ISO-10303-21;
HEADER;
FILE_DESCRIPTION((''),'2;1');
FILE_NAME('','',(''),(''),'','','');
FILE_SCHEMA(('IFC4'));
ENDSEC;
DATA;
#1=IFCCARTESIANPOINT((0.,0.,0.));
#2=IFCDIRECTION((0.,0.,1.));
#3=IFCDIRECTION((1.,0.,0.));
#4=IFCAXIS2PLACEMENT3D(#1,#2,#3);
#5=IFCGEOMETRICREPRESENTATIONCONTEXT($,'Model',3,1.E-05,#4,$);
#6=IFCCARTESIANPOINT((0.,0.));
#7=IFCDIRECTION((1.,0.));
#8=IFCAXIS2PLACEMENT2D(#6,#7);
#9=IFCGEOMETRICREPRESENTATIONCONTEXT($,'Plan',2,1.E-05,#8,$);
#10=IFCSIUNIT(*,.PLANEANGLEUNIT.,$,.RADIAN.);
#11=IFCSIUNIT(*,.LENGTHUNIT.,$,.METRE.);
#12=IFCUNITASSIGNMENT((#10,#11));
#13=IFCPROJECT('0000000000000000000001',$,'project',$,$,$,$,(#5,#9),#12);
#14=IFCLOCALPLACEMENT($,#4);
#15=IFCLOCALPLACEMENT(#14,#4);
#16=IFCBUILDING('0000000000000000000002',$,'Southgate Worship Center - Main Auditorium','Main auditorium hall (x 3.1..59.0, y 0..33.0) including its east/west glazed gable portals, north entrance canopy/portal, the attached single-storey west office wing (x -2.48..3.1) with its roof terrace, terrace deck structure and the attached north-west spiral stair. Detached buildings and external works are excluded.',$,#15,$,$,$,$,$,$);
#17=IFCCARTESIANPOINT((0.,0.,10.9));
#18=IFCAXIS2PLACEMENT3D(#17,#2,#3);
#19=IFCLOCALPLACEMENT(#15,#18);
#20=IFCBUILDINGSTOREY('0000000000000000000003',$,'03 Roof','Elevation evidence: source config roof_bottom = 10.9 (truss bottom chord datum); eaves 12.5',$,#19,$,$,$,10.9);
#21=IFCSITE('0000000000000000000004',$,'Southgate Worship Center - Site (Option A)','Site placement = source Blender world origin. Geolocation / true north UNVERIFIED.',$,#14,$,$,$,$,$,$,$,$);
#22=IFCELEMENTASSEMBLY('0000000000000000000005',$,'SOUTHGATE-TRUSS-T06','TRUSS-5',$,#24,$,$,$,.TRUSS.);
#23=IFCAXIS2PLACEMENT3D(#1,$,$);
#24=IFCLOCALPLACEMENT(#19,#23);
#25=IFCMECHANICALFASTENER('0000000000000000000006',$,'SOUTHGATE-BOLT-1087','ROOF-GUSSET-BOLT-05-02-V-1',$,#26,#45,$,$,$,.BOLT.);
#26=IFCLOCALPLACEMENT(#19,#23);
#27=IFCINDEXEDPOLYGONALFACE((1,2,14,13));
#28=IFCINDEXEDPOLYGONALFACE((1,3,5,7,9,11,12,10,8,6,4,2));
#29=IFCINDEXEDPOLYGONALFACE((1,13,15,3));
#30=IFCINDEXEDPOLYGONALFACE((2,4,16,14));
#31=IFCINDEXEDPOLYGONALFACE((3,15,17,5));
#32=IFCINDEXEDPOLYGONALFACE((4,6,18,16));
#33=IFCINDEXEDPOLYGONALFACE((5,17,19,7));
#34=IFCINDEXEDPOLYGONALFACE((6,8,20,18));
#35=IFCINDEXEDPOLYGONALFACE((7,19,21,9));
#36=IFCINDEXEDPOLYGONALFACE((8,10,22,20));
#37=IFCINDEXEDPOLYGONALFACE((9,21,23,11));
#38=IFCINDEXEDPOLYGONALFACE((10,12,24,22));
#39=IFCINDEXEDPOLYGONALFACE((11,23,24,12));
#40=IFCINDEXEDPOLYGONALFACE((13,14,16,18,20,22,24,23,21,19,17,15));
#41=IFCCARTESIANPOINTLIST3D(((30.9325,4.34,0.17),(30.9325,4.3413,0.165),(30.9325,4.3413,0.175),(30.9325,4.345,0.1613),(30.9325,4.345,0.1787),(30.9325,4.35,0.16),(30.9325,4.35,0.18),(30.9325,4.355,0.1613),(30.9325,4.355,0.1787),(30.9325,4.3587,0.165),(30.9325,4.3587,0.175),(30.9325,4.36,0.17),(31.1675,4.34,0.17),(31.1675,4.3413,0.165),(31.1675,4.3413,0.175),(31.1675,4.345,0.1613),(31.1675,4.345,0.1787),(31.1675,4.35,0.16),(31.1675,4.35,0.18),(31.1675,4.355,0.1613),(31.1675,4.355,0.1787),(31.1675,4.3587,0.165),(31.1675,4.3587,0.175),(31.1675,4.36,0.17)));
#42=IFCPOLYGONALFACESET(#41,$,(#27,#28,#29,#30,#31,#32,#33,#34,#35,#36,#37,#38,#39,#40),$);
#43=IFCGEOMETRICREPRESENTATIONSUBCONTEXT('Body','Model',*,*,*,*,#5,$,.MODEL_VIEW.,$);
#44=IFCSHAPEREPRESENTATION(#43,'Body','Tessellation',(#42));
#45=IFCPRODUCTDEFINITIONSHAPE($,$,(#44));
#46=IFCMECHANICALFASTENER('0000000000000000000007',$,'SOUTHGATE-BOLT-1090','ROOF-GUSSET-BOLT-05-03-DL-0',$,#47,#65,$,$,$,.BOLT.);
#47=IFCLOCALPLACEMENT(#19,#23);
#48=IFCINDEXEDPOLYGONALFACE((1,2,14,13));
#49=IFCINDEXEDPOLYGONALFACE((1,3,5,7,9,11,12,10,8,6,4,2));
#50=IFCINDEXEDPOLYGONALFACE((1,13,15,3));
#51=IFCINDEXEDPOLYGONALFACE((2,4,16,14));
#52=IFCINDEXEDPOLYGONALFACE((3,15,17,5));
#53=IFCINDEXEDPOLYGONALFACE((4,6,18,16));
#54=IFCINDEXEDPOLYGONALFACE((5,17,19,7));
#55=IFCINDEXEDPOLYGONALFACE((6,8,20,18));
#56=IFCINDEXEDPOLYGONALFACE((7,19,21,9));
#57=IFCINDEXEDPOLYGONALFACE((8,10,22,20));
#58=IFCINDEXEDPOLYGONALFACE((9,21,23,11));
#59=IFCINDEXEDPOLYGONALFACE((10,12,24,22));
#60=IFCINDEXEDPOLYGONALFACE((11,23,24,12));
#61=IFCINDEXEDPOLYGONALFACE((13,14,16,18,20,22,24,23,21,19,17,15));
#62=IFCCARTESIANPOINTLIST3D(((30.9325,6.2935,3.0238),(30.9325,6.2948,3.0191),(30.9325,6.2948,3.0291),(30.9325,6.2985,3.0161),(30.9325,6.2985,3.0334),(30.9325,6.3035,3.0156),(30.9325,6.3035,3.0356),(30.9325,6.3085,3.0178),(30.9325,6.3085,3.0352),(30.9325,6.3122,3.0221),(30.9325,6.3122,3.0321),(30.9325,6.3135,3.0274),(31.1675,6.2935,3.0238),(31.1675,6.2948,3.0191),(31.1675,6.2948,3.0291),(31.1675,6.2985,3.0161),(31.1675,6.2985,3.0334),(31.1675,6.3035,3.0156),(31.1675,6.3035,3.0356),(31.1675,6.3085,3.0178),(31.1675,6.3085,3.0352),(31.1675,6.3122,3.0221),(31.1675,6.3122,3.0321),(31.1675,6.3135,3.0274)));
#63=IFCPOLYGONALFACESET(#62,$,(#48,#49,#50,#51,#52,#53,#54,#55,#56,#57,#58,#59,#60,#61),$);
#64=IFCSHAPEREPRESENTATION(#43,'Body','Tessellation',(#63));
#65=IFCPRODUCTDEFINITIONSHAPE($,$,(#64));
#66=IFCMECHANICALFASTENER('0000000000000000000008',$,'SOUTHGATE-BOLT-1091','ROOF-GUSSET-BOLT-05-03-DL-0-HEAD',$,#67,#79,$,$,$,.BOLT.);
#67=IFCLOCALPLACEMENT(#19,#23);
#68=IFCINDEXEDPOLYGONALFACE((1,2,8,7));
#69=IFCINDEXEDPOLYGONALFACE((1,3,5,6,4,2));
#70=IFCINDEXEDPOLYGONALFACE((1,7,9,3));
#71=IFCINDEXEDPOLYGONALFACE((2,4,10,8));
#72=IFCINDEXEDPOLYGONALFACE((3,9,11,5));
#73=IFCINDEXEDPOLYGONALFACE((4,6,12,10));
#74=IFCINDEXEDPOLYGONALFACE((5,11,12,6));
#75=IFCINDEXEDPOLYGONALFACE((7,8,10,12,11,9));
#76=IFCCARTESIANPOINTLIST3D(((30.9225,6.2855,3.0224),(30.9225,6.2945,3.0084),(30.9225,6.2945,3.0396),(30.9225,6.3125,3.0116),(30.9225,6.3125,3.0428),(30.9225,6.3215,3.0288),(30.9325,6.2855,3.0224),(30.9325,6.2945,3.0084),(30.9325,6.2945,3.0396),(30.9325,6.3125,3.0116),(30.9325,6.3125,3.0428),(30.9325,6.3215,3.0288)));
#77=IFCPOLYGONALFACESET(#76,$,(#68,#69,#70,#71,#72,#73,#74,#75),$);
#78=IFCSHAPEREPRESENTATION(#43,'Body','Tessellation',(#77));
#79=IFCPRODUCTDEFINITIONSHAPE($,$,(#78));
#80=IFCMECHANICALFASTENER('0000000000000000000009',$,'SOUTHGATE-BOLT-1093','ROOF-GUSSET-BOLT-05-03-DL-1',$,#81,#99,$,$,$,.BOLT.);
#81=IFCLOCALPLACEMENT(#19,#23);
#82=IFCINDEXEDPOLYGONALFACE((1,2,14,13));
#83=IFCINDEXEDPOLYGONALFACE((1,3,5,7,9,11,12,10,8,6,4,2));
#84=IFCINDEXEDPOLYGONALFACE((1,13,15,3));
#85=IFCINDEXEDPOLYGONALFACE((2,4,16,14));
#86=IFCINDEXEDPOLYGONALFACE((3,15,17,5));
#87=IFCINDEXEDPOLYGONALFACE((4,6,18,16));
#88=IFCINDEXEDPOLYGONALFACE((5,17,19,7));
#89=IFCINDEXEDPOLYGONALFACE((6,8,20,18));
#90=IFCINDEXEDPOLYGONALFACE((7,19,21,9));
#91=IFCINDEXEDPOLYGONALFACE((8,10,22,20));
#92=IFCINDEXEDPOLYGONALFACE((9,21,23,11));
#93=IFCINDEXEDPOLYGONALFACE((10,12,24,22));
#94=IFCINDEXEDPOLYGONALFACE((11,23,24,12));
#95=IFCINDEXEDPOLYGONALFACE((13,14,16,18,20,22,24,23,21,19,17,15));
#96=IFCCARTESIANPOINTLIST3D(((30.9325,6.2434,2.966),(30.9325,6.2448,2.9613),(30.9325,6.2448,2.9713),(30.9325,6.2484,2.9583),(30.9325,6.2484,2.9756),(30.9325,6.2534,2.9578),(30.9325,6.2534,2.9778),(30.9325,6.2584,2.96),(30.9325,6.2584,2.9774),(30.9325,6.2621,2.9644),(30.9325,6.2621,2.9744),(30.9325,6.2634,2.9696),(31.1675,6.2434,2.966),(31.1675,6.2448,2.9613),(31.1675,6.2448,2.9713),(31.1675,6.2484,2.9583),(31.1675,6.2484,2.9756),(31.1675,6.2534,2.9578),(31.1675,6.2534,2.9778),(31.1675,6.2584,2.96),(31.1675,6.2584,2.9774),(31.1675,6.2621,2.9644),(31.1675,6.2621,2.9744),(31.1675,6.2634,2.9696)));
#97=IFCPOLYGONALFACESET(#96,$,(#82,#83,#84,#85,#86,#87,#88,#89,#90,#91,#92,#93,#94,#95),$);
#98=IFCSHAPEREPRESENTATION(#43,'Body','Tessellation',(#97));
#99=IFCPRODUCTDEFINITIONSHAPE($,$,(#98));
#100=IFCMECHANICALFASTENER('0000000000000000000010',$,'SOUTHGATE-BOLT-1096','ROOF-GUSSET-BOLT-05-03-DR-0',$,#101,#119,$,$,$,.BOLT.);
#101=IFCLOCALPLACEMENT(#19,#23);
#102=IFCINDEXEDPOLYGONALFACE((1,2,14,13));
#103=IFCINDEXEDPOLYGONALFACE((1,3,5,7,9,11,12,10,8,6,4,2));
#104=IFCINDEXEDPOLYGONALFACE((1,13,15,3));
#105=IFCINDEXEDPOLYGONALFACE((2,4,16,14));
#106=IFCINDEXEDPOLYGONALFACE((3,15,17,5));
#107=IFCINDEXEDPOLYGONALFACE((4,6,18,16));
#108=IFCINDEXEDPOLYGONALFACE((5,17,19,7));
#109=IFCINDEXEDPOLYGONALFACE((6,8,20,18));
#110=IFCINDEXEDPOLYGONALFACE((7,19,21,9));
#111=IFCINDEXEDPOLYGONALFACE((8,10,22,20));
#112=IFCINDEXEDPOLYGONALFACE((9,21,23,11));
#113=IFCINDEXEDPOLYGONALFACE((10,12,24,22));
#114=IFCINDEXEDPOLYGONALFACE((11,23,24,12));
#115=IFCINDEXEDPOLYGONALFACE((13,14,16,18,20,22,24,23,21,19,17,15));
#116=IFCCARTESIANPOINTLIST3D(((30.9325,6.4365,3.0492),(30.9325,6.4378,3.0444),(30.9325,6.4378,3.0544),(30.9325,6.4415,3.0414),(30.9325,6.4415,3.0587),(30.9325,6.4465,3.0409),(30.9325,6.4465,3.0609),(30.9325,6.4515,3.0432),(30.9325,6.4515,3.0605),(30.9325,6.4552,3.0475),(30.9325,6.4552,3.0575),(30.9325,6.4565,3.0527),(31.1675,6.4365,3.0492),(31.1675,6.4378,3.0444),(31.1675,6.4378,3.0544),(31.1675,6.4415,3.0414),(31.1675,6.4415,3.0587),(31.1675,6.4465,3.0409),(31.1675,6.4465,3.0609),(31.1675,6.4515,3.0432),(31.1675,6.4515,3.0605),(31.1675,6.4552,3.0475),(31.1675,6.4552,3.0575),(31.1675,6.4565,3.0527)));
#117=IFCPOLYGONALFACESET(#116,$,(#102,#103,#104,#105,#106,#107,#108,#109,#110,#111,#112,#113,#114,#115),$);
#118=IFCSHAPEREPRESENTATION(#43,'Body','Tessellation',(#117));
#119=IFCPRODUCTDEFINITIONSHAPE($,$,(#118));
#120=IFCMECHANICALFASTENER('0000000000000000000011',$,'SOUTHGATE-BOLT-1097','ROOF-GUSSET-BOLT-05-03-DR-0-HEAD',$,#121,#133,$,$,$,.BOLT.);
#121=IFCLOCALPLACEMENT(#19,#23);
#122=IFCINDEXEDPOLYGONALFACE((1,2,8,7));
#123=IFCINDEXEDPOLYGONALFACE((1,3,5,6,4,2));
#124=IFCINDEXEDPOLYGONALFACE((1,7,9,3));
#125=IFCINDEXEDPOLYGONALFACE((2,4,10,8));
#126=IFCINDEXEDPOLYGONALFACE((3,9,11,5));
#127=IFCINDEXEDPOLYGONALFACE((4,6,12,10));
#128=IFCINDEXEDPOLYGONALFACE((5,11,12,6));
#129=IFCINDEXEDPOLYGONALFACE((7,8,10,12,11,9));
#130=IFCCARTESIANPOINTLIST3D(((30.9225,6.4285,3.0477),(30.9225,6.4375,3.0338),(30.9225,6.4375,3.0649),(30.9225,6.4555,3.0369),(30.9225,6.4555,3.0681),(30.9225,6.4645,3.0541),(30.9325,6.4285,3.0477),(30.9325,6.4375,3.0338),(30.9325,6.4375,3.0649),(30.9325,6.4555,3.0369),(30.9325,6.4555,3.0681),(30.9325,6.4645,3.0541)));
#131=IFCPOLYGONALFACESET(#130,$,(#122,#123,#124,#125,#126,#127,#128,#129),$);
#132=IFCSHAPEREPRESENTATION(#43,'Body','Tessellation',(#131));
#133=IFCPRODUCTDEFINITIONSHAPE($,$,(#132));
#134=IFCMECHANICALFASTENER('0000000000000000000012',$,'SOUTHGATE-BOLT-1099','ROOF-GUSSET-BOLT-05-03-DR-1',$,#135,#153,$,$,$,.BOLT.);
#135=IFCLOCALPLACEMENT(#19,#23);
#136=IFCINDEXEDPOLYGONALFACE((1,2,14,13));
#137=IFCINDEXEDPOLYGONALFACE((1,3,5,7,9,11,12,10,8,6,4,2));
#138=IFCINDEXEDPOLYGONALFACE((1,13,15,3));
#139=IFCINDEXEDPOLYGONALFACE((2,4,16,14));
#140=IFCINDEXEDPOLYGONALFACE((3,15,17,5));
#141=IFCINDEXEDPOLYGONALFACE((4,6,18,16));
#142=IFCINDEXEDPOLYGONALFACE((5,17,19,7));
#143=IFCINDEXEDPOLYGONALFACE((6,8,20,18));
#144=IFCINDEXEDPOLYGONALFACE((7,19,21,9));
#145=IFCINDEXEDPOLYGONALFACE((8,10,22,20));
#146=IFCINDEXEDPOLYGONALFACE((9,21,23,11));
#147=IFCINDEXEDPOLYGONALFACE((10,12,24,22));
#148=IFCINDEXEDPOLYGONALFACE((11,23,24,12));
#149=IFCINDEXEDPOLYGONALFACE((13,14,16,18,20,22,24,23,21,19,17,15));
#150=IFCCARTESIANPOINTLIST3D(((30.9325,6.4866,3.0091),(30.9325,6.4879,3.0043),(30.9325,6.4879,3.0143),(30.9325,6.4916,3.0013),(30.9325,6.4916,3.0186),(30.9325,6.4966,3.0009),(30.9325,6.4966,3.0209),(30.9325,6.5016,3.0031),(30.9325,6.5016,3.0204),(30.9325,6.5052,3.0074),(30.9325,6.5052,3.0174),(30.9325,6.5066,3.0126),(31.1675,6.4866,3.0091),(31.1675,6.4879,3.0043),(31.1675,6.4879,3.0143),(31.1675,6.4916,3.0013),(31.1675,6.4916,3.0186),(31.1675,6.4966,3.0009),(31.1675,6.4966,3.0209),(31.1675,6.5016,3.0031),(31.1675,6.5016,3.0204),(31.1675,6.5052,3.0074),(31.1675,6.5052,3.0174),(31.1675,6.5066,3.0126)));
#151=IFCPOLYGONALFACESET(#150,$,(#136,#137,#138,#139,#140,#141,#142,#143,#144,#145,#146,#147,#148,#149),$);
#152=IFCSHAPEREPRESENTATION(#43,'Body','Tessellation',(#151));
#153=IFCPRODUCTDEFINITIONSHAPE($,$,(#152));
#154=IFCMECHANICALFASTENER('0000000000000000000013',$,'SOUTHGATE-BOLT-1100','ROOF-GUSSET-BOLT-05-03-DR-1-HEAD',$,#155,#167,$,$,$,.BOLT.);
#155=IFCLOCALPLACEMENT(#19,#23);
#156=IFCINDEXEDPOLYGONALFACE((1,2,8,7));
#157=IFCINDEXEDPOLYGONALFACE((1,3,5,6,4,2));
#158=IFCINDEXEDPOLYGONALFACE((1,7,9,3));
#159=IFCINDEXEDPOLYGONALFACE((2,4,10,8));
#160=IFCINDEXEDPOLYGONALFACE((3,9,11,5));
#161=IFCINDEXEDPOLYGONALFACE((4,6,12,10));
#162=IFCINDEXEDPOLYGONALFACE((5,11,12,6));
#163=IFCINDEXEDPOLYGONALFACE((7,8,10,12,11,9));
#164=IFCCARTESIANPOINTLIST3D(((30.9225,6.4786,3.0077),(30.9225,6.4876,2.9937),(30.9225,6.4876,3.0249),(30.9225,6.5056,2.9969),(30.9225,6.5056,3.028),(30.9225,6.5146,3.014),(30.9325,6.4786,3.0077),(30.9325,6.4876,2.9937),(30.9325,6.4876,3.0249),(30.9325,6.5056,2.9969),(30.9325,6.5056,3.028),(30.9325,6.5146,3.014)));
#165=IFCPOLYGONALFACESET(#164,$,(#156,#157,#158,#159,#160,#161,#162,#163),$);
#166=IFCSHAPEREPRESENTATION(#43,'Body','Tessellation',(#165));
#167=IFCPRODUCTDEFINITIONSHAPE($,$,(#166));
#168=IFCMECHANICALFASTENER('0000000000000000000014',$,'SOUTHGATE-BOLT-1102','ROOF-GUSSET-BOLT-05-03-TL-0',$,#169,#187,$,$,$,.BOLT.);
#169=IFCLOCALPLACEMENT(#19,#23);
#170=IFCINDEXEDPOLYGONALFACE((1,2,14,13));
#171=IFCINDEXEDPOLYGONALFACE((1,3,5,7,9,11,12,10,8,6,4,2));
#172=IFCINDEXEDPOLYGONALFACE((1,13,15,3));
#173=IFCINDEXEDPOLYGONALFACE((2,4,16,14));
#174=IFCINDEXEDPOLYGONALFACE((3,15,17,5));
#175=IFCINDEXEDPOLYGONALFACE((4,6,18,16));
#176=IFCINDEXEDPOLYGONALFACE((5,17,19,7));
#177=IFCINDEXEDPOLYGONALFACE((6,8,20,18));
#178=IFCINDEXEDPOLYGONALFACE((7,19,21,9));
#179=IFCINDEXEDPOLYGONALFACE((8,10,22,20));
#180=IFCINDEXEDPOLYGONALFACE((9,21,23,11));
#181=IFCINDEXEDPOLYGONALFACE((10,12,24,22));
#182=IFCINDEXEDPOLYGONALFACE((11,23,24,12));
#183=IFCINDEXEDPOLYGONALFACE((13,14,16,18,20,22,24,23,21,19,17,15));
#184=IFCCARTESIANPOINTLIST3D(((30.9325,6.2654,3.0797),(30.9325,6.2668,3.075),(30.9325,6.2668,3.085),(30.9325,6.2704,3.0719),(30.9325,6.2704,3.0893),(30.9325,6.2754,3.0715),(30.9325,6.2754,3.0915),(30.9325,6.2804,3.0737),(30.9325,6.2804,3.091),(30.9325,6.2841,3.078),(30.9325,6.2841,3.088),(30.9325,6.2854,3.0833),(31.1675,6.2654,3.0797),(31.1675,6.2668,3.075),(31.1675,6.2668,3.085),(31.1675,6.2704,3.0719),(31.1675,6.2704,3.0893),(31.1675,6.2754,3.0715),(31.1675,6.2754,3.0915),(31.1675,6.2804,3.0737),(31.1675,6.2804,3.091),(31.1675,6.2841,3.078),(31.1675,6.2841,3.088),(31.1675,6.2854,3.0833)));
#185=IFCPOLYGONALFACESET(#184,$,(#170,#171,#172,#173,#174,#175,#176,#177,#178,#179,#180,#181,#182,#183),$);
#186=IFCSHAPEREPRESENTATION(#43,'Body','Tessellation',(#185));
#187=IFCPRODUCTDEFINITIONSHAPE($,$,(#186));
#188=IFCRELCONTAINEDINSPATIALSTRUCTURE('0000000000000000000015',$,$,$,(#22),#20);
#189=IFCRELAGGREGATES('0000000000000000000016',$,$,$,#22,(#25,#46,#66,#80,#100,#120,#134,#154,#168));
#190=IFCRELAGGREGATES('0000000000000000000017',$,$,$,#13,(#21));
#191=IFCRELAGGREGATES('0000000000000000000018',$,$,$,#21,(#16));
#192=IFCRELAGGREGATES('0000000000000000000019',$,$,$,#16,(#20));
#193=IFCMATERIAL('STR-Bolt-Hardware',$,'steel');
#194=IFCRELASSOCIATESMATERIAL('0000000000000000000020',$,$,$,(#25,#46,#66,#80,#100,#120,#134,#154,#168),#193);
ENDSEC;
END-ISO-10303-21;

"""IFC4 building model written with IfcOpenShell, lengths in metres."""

from ifc_helpers import new_model, si_unit, frame, origin_with_axes, origin_2d_with_axis, place, context, subcontext, project, spatial, indexed_curve, outline, extrude, material, element, aggregate, save


model = new_model("IFC4")

# Units and contexts
model_context = context("Model", 3, precision=1e-05, world=origin_with_axes())
plan_context = context("Plan", 2, precision=1e-05, world=origin_2d_with_axis())
body_context = subcontext(model_context, "Body", "Model", "MODEL_VIEW")
ifc_project = project(units=[si_unit("PLANEANGLEUNIT", "RADIAN"), si_unit("LENGTHUNIT", "METRE")], contexts=[model_context, plan_context])

# Site, building, storey
site_placement = place(None, origin_with_axes())
site = spatial("IfcSite", under=ifc_project, at=site_placement, Name="Southgate Worship Center - Site (Option A)", Description="Site placement = source Blender world origin. Geolocation / true north UNVERIFIED.")
building_placement = place(site_placement, origin_with_axes())
building = spatial("IfcBuilding", under=site, at=building_placement, Name="Southgate Worship Center - Main Auditorium", Description="Main auditorium hall (x 3.1..59.0, y 0..33.0) including its east/west glazed gable portals, north entrance canopy/portal, the attached single-storey west office wing (x -2.48..3.1) with its roof terrace, terrace deck structure and the attached north-west spiral stair. Detached buildings and external works are excluded.")
storey_placement = place(building_placement, frame((0.0, 0.0, 10.9), z_axis=(0.0, 0.0, 1.0), x_axis=(1.0, 0.0, 0.0)))
storey = spatial("IfcBuildingStorey", under=building, at=storey_placement, Name="03 Roof", Description="Elevation evidence: source config roof_bottom = 10.9 (truss bottom chord datum); eaves 12.5", Elevation=10.9)

# Element assembly, mechanical fasteners
assembly_placement = place(storey_placement, origin_with_axes())
assembly = element("IfcElementAssembly", 1, at=assembly_placement, inside=storey, Name="SOUTHGATE-TRUSS-T06", Description="TRUSS-5", PredefinedType="TRUSS")
ifc_material = material(Name="STR-Bolt-Hardware", Category="steel")
mechanical_fastener_1_placement = place(assembly_placement, frame((30.9325, 4.34, 0.16), z_axis=(0.0, 0.0, 1.0), x_axis=(1.0, 0.0, 0.0)))
mechanical_fastener_1 = element("IfcMechanicalFastener", 2, at=mechanical_fastener_1_placement, material=ifc_material, Name="SOUTHGATE-BOLT-1087", Description="ROOF-GUSSET-BOLT-05-02-V-1", PredefinedType="BOLT", context=body_context, shape_type="SweptSolid", body=[
    extrude(outline(indexed_curve([(0.0, 0.0), (0.0013, -0.005), (0.005, -0.0087), (0.01, -0.01), (0.015, -0.0087), (0.0187, -0.005), (0.02, 0.0), (0.0187, 0.005), (0.015, 0.0087), (0.01, 0.01), (0.005, 0.0087), (0.0013, 0.005), (0.0, 0.0)], self_intersect=False)), frame((0.0, 0.0, 0.01), z_axis=(1.0, 0.0, 0.0), x_axis=(0.0, 1.0, 0.0)), (0.0, 0.0, 1.0), 0.235),
])
mechanical_fastener_2_placement = place(assembly_placement, frame((30.9325, 6.2935, 3.0156), z_axis=(0.0, 0.0, 1.0), x_axis=(1.0, 0.0, 0.0)))
mechanical_fastener_2 = element("IfcMechanicalFastener", 3, at=mechanical_fastener_2_placement, material=ifc_material, Name="SOUTHGATE-BOLT-1090", Description="ROOF-GUSSET-BOLT-05-03-DL-0", PredefinedType="BOLT", context=body_context, shape_type="SweptSolid", body=[
    extrude(outline(indexed_curve([(0.0, 0.0), (0.0013, -0.0048), (0.005, -0.0078), (0.01, -0.0082), (0.015, -0.006), (0.0187, -0.0017), (0.02, 0.0035), (0.0187, 0.0083), (0.015, 0.0113), (0.01, 0.0118), (0.005, 0.0095), (0.0013, 0.0052), (0.0, 0.0)], self_intersect=False)), frame((0.0, 0.0, 0.0082), z_axis=(1.0, 0.0, 0.0), x_axis=(0.0, 1.0, 0.0)), (0.0, 0.0, 1.0), 0.235),
])
mechanical_fastener_3_placement = place(assembly_placement, frame((30.9225, 6.2855, 3.0084), z_axis=(0.0, 0.0, 1.0), x_axis=(1.0, 0.0, 0.0)))
mechanical_fastener_3 = element("IfcMechanicalFastener", 4, at=mechanical_fastener_3_placement, material=ifc_material, Name="SOUTHGATE-BOLT-1091", Description="ROOF-GUSSET-BOLT-05-03-DL-0-HEAD", PredefinedType="BOLT", context=body_context, shape_type="SweptSolid", body=[
    extrude(outline(indexed_curve([(0.0, 0.0), (0.009, -0.014), (0.027, -0.0108), (0.036, 0.0064), (0.027, 0.0204), (0.009, 0.0172), (0.0, 0.0)], self_intersect=False)), frame((0.0, 0.0, 0.014), z_axis=(1.0, 0.0, 0.0), x_axis=(0.0, 1.0, 0.0)), (0.0, 0.0, 1.0), 0.01),
])
mechanical_fastener_4_placement = place(assembly_placement, frame((30.9325, 6.2434, 2.9578), z_axis=(0.0, 0.0, 1.0), x_axis=(1.0, 0.0, 0.0)))
mechanical_fastener_4 = element("IfcMechanicalFastener", 5, at=mechanical_fastener_4_placement, material=ifc_material, Name="SOUTHGATE-BOLT-1093", Description="ROOF-GUSSET-BOLT-05-03-DL-1", PredefinedType="BOLT", context=body_context, shape_type="SweptSolid", body=[
    extrude(outline(indexed_curve([(0.0, 0.0), (0.0013, -0.0048), (0.005, -0.0078), (0.01, -0.0082), (0.015, -0.006), (0.0187, -0.0017), (0.02, 0.0035), (0.0187, 0.0083), (0.015, 0.0113), (0.01, 0.0118), (0.005, 0.0095), (0.0013, 0.0052), (0.0, 0.0)], self_intersect=False)), frame((0.0, 0.0, 0.0082), z_axis=(1.0, 0.0, 0.0), x_axis=(0.0, 1.0, 0.0)), (0.0, 0.0, 1.0), 0.235),
])
mechanical_fastener_5_placement = place(assembly_placement, frame((30.9325, 6.4365, 3.0409), z_axis=(0.0, 0.0, 1.0), x_axis=(1.0, 0.0, 0.0)))
mechanical_fastener_5 = element("IfcMechanicalFastener", 6, at=mechanical_fastener_5_placement, material=ifc_material, Name="SOUTHGATE-BOLT-1096", Description="ROOF-GUSSET-BOLT-05-03-DR-0", PredefinedType="BOLT", context=body_context, shape_type="SweptSolid", body=[
    extrude(outline(indexed_curve([(0.0, 0.0), (0.0013, -0.0048), (0.005, -0.0078), (0.01, -0.0082), (0.015, -0.006), (0.0187, -0.0017), (0.02, 0.0035), (0.0187, 0.0083), (0.015, 0.0113), (0.01, 0.0118), (0.005, 0.0095), (0.0013, 0.0052), (0.0, 0.0)], self_intersect=False)), frame((0.0, 0.0, 0.0083), z_axis=(1.0, 0.0, 0.0), x_axis=(0.0, 1.0, 0.0)), (0.0, 0.0, 1.0), 0.235),
])
mechanical_fastener_6_placement = place(assembly_placement, frame((30.9225, 6.4285, 3.0338), z_axis=(0.0, 0.0, 1.0), x_axis=(1.0, 0.0, 0.0)))
mechanical_fastener_6 = element("IfcMechanicalFastener", 7, at=mechanical_fastener_6_placement, material=ifc_material, Name="SOUTHGATE-BOLT-1097", Description="ROOF-GUSSET-BOLT-05-03-DR-0-HEAD", PredefinedType="BOLT", context=body_context, shape_type="SweptSolid", body=[
    extrude(outline(indexed_curve([(0.0, 0.0), (0.009, -0.014), (0.027, -0.0108), (0.036, 0.0064), (0.027, 0.0204), (0.009, 0.0172), (0.0, 0.0)], self_intersect=False)), frame((0.0, 0.0, 0.0139), z_axis=(1.0, 0.0, 0.0), x_axis=(0.0, 1.0, 0.0)), (0.0, 0.0, 1.0), 0.01),
])
mechanical_fastener_7_placement = place(assembly_placement, frame((30.9325, 6.4866, 3.0009), z_axis=(0.0, 0.0, 1.0), x_axis=(1.0, 0.0, 0.0)))
mechanical_fastener_7 = element("IfcMechanicalFastener", 8, at=mechanical_fastener_7_placement, material=ifc_material, Name="SOUTHGATE-BOLT-1099", Description="ROOF-GUSSET-BOLT-05-03-DR-1", PredefinedType="BOLT", context=body_context, shape_type="SweptSolid", body=[
    extrude(outline(indexed_curve([(0.0, 0.0), (0.0013, -0.0048), (0.005, -0.0078), (0.01, -0.0082), (0.015, -0.006), (0.0187, -0.0017), (0.02, 0.0035), (0.0187, 0.0083), (0.015, 0.0113), (0.01, 0.0118), (0.005, 0.0095), (0.0013, 0.0052), (0.0, 0.0)], self_intersect=False)), frame((0.0, 0.0, 0.0082), z_axis=(1.0, 0.0, 0.0), x_axis=(0.0, 1.0, 0.0)), (0.0, 0.0, 1.0), 0.235),
])
mechanical_fastener_8_placement = place(assembly_placement, frame((30.9225, 6.4786, 2.9937), z_axis=(0.0, 0.0, 1.0), x_axis=(1.0, 0.0, 0.0)))
mechanical_fastener_8 = element("IfcMechanicalFastener", 9, at=mechanical_fastener_8_placement, material=ifc_material, Name="SOUTHGATE-BOLT-1100", Description="ROOF-GUSSET-BOLT-05-03-DR-1-HEAD", PredefinedType="BOLT", context=body_context, shape_type="SweptSolid", body=[
    extrude(outline(indexed_curve([(0.0, 0.0), (0.009, -0.014), (0.027, -0.0108), (0.036, 0.0064), (0.027, 0.0204), (0.009, 0.0172), (0.0, 0.0)], self_intersect=False)), frame((0.0, 0.0, 0.014), z_axis=(1.0, 0.0, 0.0), x_axis=(0.0, 1.0, 0.0)), (0.0, 0.0, 1.0), 0.01),
])
mechanical_fastener_9_placement = place(assembly_placement, frame((30.9325, 6.2654, 3.0715), z_axis=(0.0, 0.0, 1.0), x_axis=(1.0, 0.0, 0.0)))
mechanical_fastener_9 = element("IfcMechanicalFastener", 10, at=mechanical_fastener_9_placement, material=ifc_material, Name="SOUTHGATE-BOLT-1102", Description="ROOF-GUSSET-BOLT-05-03-TL-0", PredefinedType="BOLT", context=body_context, shape_type="SweptSolid", body=[
    extrude(outline(indexed_curve([(0.0, 0.0), (0.0013, -0.0048), (0.005, -0.0078), (0.01, -0.0082), (0.015, -0.006), (0.0187, -0.0017), (0.02, 0.0035), (0.0187, 0.0083), (0.015, 0.0113), (0.01, 0.0118), (0.005, 0.0095), (0.0013, 0.0052), (0.0, 0.0)], self_intersect=False)), frame((0.0, 0.0, 0.0082), z_axis=(1.0, 0.0, 0.0), x_axis=(0.0, 1.0, 0.0)), (0.0, 0.0, 1.0), 0.235),
])
aggregate(assembly, [mechanical_fastener_1, mechanical_fastener_2, mechanical_fastener_3, mechanical_fastener_4, mechanical_fastener_5, mechanical_fastener_6, mechanical_fastener_7, mechanical_fastener_8, mechanical_fastener_9])

save(model, "model.ifc")
